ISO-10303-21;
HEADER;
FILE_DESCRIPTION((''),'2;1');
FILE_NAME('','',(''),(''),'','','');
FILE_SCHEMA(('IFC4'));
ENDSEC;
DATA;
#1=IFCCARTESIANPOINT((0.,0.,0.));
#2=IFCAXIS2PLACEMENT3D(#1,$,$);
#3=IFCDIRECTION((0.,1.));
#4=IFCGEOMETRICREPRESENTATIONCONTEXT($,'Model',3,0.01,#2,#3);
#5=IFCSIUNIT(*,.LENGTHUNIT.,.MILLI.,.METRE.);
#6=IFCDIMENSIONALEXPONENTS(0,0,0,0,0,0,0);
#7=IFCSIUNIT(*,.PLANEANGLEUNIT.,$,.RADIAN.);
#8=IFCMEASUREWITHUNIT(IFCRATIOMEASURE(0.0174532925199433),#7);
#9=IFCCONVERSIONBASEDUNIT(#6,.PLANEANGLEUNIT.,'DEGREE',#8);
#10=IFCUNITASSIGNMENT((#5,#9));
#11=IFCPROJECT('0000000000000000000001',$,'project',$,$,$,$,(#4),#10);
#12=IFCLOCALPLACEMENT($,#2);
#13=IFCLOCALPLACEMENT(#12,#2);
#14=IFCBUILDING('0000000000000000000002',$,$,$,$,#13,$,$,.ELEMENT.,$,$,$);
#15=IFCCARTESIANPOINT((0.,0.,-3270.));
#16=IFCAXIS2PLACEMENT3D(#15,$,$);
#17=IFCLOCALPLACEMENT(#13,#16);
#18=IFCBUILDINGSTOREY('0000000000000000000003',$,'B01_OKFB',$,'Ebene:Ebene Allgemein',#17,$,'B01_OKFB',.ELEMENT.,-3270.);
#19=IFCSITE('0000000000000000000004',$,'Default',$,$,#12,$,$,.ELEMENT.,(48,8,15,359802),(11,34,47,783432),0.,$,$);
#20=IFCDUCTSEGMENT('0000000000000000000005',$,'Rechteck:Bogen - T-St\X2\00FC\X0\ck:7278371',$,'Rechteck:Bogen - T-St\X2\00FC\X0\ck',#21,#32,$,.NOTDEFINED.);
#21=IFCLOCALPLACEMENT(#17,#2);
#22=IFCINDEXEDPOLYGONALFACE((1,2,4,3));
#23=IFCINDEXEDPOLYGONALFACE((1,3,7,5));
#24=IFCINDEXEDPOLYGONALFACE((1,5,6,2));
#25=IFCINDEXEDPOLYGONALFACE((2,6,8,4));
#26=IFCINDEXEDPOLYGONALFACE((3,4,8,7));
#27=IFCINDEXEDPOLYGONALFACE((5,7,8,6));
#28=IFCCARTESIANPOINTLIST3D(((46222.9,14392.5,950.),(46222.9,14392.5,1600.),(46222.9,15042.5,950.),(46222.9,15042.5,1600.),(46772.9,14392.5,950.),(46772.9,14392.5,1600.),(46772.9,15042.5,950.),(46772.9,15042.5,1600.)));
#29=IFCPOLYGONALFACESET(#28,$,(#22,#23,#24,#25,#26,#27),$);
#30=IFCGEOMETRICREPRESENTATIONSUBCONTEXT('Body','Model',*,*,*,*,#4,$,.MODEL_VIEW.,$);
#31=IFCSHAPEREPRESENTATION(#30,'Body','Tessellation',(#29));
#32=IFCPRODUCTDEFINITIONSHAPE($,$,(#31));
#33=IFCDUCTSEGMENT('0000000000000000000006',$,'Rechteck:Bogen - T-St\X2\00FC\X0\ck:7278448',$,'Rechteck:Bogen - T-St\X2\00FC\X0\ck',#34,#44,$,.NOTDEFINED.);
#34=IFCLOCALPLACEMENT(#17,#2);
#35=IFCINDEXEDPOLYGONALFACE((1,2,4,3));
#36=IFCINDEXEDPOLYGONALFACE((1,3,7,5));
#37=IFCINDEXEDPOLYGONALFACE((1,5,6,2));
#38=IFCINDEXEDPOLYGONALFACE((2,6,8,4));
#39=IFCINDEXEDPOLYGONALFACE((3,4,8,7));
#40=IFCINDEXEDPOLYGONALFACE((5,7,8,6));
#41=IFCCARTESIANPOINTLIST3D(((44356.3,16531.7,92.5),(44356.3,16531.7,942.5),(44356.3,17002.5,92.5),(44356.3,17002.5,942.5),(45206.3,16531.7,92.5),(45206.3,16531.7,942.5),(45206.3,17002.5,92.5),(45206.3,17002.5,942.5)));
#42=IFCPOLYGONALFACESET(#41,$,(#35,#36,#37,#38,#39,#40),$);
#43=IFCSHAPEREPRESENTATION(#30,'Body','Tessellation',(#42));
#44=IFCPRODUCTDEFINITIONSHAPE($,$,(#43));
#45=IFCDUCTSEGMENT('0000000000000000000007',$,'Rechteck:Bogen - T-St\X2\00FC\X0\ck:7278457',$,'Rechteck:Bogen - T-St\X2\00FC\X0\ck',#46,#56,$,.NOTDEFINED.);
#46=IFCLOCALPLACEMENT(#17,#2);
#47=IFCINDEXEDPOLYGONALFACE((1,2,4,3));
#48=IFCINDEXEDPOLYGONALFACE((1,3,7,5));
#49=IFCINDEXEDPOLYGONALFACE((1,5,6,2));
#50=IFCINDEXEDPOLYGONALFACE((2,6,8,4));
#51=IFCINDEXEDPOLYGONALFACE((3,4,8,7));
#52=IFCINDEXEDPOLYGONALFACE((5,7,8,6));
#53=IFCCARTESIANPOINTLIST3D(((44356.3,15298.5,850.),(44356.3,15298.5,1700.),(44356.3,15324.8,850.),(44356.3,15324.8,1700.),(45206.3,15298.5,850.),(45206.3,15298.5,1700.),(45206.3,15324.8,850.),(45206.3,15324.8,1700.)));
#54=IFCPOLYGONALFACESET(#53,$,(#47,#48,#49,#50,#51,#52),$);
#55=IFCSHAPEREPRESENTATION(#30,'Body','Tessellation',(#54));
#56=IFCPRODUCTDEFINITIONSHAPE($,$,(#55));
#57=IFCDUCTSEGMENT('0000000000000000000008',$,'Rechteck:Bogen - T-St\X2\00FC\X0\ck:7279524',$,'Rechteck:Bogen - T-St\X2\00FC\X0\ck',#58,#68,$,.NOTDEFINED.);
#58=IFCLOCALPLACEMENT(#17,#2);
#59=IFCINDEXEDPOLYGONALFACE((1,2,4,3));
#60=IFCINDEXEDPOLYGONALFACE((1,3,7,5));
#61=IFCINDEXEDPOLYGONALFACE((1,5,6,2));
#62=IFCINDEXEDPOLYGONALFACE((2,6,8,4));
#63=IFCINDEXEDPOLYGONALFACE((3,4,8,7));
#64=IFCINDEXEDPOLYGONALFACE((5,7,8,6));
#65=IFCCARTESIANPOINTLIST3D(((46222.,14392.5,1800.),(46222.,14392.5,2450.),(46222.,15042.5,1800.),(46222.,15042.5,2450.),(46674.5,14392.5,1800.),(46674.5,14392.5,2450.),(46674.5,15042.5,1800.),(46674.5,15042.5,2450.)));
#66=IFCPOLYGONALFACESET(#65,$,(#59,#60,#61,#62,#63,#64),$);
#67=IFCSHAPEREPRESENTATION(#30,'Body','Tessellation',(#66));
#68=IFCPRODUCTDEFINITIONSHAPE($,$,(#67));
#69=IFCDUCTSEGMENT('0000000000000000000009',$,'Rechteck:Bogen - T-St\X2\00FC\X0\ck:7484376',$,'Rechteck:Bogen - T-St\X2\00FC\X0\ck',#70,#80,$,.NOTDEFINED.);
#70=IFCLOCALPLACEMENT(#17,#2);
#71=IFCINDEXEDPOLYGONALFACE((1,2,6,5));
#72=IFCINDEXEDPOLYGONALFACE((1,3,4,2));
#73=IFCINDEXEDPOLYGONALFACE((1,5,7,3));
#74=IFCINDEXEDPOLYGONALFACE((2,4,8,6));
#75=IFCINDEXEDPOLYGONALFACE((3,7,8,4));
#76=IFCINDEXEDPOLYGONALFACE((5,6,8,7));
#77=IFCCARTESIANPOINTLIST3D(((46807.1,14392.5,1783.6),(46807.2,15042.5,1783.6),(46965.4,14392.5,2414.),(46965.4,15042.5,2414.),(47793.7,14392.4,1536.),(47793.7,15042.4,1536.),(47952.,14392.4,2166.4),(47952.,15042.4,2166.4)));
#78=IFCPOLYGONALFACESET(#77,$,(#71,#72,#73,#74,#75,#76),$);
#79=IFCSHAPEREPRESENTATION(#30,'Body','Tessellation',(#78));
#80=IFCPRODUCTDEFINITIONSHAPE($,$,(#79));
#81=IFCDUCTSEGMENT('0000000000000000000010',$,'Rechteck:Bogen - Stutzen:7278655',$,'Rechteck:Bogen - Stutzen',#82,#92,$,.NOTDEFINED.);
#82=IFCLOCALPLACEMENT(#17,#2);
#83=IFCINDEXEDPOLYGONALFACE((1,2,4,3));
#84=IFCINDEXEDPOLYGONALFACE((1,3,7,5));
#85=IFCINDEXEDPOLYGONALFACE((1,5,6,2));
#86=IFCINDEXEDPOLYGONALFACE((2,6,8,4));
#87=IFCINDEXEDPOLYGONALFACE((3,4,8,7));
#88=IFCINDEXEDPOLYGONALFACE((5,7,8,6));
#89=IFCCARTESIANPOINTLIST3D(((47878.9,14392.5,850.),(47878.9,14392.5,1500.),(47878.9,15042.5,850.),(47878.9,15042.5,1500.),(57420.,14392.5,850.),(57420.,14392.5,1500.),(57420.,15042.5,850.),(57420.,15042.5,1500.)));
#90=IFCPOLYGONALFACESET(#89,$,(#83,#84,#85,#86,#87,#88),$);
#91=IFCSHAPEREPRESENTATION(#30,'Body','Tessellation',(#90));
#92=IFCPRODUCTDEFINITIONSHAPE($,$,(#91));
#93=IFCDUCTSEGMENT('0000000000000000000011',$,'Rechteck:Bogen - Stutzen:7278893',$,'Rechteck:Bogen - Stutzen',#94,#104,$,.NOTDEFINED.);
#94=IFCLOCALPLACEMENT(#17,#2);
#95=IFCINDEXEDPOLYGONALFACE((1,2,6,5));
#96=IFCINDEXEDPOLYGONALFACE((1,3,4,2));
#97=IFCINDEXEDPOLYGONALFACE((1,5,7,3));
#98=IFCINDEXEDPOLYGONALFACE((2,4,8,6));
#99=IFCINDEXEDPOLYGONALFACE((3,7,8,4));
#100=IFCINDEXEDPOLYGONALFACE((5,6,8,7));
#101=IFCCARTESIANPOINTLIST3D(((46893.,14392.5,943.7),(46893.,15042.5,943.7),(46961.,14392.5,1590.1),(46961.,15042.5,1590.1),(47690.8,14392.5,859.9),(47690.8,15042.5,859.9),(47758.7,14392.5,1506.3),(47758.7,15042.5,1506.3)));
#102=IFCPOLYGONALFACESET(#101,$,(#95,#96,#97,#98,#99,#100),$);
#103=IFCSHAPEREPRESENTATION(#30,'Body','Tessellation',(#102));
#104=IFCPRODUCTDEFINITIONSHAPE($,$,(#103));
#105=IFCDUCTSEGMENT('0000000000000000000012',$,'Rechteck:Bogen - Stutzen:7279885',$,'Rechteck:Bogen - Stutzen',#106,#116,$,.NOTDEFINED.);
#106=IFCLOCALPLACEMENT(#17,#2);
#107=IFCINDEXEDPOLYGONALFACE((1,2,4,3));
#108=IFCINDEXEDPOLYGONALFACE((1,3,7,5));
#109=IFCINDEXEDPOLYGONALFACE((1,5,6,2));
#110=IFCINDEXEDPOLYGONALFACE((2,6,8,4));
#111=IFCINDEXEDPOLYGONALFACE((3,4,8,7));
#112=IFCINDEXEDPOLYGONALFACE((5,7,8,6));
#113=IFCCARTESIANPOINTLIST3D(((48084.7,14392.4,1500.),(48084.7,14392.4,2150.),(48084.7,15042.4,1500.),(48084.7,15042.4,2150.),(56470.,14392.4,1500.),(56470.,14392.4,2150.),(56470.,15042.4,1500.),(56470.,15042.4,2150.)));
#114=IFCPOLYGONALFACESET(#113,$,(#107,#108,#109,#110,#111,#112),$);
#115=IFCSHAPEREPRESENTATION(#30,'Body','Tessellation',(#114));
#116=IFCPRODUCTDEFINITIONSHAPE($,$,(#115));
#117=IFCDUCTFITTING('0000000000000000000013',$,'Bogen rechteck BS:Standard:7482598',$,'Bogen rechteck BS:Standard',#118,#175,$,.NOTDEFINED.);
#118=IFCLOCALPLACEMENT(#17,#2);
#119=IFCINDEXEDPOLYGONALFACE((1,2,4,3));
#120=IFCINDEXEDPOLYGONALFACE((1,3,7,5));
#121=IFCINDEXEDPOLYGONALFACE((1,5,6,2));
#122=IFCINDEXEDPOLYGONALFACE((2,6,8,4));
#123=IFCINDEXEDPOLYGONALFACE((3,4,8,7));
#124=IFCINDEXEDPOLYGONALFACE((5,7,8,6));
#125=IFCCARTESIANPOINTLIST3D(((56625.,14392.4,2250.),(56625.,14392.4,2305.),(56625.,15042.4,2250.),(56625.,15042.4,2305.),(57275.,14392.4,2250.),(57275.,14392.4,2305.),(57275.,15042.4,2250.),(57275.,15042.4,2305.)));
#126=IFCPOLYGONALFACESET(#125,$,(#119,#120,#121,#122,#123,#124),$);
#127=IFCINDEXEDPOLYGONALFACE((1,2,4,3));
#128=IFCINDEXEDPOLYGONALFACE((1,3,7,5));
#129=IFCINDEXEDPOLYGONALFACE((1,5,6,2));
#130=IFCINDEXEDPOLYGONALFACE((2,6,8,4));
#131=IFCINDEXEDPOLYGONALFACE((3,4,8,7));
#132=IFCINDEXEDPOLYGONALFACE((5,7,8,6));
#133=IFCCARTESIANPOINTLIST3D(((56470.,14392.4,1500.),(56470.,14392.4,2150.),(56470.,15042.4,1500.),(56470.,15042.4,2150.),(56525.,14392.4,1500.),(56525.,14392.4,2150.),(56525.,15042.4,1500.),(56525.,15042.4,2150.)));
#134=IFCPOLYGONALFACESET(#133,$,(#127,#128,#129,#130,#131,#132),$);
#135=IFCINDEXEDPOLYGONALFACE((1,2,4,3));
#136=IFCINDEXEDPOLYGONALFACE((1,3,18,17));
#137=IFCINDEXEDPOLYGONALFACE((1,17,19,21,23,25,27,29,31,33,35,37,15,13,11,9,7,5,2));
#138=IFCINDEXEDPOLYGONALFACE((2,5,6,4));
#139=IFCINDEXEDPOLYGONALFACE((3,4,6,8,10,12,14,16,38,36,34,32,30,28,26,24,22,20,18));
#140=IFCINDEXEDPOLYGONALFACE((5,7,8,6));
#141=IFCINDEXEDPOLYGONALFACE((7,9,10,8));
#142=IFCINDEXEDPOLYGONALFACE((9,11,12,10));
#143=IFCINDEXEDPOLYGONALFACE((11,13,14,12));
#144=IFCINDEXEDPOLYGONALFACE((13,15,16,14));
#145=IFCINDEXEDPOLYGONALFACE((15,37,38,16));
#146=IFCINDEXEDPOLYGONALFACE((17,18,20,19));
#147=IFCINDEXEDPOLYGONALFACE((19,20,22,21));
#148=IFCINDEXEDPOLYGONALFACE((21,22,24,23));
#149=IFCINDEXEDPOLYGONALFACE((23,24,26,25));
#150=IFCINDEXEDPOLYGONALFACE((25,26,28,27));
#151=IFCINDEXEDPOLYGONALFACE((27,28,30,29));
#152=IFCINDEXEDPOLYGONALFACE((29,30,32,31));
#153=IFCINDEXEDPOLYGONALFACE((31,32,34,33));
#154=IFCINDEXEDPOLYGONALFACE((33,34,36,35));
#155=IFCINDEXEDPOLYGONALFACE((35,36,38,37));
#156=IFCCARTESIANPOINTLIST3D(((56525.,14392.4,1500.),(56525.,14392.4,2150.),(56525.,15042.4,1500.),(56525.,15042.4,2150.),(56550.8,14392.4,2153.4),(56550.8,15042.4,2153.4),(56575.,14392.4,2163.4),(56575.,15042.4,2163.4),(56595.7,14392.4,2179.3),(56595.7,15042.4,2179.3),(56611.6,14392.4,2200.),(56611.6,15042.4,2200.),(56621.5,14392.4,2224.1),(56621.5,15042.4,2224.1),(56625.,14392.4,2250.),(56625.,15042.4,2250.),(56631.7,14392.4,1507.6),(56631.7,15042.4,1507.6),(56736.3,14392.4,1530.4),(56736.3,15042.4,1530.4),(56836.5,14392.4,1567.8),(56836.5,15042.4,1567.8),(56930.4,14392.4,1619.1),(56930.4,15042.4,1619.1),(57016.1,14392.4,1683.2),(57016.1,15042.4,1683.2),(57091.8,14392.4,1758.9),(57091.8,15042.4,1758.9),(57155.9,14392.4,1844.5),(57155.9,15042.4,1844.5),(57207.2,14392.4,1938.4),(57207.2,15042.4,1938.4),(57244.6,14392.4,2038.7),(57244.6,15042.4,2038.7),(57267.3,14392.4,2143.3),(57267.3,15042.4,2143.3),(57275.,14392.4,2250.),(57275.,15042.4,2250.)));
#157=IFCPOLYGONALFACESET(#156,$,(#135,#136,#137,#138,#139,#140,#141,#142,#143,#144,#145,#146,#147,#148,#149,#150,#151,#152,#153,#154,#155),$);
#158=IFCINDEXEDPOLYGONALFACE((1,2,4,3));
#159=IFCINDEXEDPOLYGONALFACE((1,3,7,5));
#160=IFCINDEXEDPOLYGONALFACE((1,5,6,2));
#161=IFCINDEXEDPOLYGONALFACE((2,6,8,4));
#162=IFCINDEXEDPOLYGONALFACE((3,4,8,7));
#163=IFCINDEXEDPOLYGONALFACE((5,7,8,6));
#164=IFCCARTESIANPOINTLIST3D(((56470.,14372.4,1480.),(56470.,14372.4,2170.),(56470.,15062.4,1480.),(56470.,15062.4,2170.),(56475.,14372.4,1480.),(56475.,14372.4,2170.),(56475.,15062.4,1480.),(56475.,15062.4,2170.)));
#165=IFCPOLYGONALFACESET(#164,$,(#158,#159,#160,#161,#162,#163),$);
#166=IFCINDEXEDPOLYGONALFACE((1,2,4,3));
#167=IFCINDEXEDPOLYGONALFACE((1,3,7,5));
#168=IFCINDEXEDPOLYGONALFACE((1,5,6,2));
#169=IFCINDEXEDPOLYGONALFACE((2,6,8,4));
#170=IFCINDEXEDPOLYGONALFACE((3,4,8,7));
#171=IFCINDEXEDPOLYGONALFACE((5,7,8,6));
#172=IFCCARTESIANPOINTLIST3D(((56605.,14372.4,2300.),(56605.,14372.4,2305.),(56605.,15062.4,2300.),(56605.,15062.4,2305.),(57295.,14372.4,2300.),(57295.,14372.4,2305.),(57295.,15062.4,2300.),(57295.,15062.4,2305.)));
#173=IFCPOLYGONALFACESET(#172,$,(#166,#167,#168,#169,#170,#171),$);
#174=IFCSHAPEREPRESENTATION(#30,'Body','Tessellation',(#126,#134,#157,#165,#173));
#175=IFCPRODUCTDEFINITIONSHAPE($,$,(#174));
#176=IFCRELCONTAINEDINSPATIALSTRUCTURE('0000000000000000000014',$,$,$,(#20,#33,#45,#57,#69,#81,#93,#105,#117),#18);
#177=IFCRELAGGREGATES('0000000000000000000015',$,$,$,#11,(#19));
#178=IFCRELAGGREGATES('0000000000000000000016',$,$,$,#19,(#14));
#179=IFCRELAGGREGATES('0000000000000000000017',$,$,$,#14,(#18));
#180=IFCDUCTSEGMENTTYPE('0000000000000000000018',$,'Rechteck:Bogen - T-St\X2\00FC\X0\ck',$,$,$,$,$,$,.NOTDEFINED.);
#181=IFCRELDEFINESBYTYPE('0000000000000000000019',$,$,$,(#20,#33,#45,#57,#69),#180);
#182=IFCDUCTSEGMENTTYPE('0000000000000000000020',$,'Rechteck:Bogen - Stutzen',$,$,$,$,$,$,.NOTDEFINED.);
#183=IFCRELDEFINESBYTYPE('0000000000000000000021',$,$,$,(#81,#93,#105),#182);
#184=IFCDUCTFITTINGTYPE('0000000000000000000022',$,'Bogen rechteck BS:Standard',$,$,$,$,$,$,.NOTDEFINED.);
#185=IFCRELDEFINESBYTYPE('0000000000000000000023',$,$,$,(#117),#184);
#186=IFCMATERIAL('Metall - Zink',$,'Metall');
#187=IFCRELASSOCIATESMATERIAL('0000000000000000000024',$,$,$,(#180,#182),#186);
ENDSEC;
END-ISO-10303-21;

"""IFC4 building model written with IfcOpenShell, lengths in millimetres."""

from ifc_helpers import new_model, entity, si_unit, converted_unit, direction, frame, frame_2d, origin, origin_2d_with_axis, place, context, subcontext, project, spatial, polyline, circle_curve, parameter, trimmed, segment, composite_curve, rectangle, outline, extrude, source, transform, mapped, material, type_object, type_shapes, element, save


model = new_model("IFC4")

# Units and contexts
model_context = context("Model", 3, precision=0.01, world=origin(), true_north=direction((0.0, 1.0)))
body_context = subcontext(model_context, "Body", "Model", "MODEL_VIEW")
ifc_project = project(units=[si_unit("LENGTHUNIT", "METRE", prefix="MILLI"), converted_unit("PLANEANGLEUNIT", "DEGREE", entity("IfcRatioMeasure", 0.0174532925199433), si_unit("PLANEANGLEUNIT", "RADIAN"), dimensions=[0, 0, 0, 0, 0, 0, 0])], contexts=[model_context])

# Site, building, storey
site_placement = place(None, origin())
site = spatial("IfcSite", under=ifc_project, at=site_placement, Name="Default", CompositionType="ELEMENT", RefLatitude=(48, 8, 15, 359802), RefLongitude=(11, 34, 47, 783432), RefElevation=0.0)
building_placement = place(site_placement, origin())
building = spatial("IfcBuilding", under=site, at=building_placement, CompositionType="ELEMENT")
storey_placement = place(building_placement, frame((0.0, 0.0, -3270.0)))
storey = spatial("IfcBuildingStorey", under=building, at=storey_placement, Name="B01_OKFB", ObjectType="Ebene:Ebene Allgemein", LongName="B01_OKFB", CompositionType="ELEMENT", Elevation=-3270.0)

# Duct segments
ifc_material = material(Name="Metall - Zink", Category="Metall")
duct_segment_type_1 = type_object("IfcDuctSegmentType", Name="Rechteck:Bogen - T-Stück", PredefinedType="NOTDEFINED", material=ifc_material)
duct_segment_1_placement = place(storey_placement, frame((46222.9, 14392.5, 950.0)))
element("IfcDuctSegment", 1, at=duct_segment_1_placement, inside=storey, type_object=duct_segment_type_1, Name="Rechteck:Bogen - T-Stück:7278371", ObjectType="Rechteck:Bogen - T-Stück", PredefinedType="NOTDEFINED", context=body_context, shape_type="SweptSolid", body=[
    extrude(rectangle(XDim=550.0, YDim=650.0, at=frame_2d((0.0, 0.0), x_axis=(1.0, 0.0))), frame((275.0, 325.0, 0.0)), (0.0, 0.0, 1.0), 650.0),
])
duct_segment_2_placement = place(storey_placement, frame((44356.3, 16531.7, 92.5)))
element("IfcDuctSegment", 2, at=duct_segment_2_placement, inside=storey, type_object=duct_segment_type_1, Name="Rechteck:Bogen - T-Stück:7278448", ObjectType="Rechteck:Bogen - T-Stück", PredefinedType="NOTDEFINED", context=body_context, shape_type="SweptSolid", body=[
    extrude(rectangle(XDim=470.8, YDim=850.0, at=frame_2d((0.0, 0.0), x_axis=(1.0, 0.0))), frame((425.0, 235.4, 0.0), z_axis=(0.0, 0.0, 1.0), x_axis=(0.0, -1.0, 0.0)), (0.0, 0.0, 1.0), 850.0),
])
duct_segment_3_placement = place(storey_placement, frame((44356.3, 15298.5, 850.0)))
element("IfcDuctSegment", 3, at=duct_segment_3_placement, inside=storey, type_object=duct_segment_type_1, Name="Rechteck:Bogen - T-Stück:7278457", ObjectType="Rechteck:Bogen - T-Stück", PredefinedType="NOTDEFINED", context=body_context, shape_type="SweptSolid", body=[
    extrude(rectangle(XDim=26.2, YDim=850.0, at=frame_2d((0.0, 0.0), x_axis=(1.0, 0.0))), frame((425.0, 13.1, 0.0), z_axis=(0.0, 0.0, 1.0), x_axis=(0.0, 1.0, 0.0)), (0.0, 0.0, 1.0), 850.0),
])
duct_segment_4_placement = place(storey_placement, frame((46222.0, 14392.5, 1800.0)))
element("IfcDuctSegment", 4, at=duct_segment_4_placement, inside=storey, type_object=duct_segment_type_1, Name="Rechteck:Bogen - T-Stück:7279524", ObjectType="Rechteck:Bogen - T-Stück", PredefinedType="NOTDEFINED", context=body_context, shape_type="SweptSolid", body=[
    extrude(rectangle(XDim=452.5, YDim=650.0, at=origin_2d_with_axis()), frame((226.2, 325.0, 0.0)), (0.0, 0.0, 1.0), 650.0),
])
duct_segment_5_placement = place(storey_placement, frame((46807.1, 14392.4, 1536.0)))
element("IfcDuctSegment", 5, at=duct_segment_5_placement, inside=storey, type_object=duct_segment_type_1, Name="Rechteck:Bogen - T-Stück:7484376", ObjectType="Rechteck:Bogen - T-Stück", PredefinedType="NOTDEFINED", context=body_context, shape_type="SweptSolid", body=[
    extrude(rectangle(XDim=650.0, YDim=650.0, at=frame_2d((0.0, 0.0), x_axis=(0.0, 1.0))), frame((79.1, 325.0, 562.9), z_axis=(0.969911, -0.000036, -0.243458), x_axis=(0.000037, 1.0, 0.0)), (0.0, 0.0, 1.0), 1017.2),
])

# Duct segments
duct_segment_type_2 = type_object("IfcDuctSegmentType", Name="Rechteck:Bogen - Stutzen", PredefinedType="NOTDEFINED", material=ifc_material)
duct_segment_6_placement = place(storey_placement, frame((47878.9, 14392.5, 850.0)))
element("IfcDuctSegment", 6, at=duct_segment_6_placement, inside=storey, type_object=duct_segment_type_2, Name="Rechteck:Bogen - Stutzen:7278655", ObjectType="Rechteck:Bogen - Stutzen", PredefinedType="NOTDEFINED", context=body_context, shape_type="SweptSolid", body=[
    extrude(rectangle(XDim=9541.1, YDim=650.0, at=frame_2d((0.0, 0.0), x_axis=(1.0, 0.0))), frame((4770.5, 325.0, 0.0), z_axis=(0.0, 0.0, 1.0), x_axis=(-1.0, 0.0, 0.0)), (0.0, 0.0, 1.0), 650.0),
])
duct_segment_7_placement = place(storey_placement, frame((46893.0, 14392.5, 859.9)))
element("IfcDuctSegment", 7, at=duct_segment_7_placement, inside=storey, type_object=duct_segment_type_2, Name="Rechteck:Bogen - Stutzen:7278893", ObjectType="Rechteck:Bogen - Stutzen", PredefinedType="NOTDEFINED", context=body_context, shape_type="SweptSolid", body=[
    extrude(rectangle(XDim=650.0, YDim=650.0, at=frame_2d((0.0, 0.0), x_axis=(0.0, 1.0))), frame((34.0, 325.0, 407.1), z_axis=(0.994522, 0.0, -0.104528), x_axis=(0.0, 1.0, 0.0)), (0.0, 0.0, 1.0), 802.1),
])
duct_segment_8_placement = place(storey_placement, frame((48084.7, 14392.4, 1500.0)))
element("IfcDuctSegment", 8, at=duct_segment_8_placement, inside=storey, type_object=duct_segment_type_2, Name="Rechteck:Bogen - Stutzen:7279885", ObjectType="Rechteck:Bogen - Stutzen", PredefinedType="NOTDEFINED", context=body_context, shape_type="SweptSolid", body=[
    extrude(rectangle(XDim=8385.3, YDim=650.0, at=origin_2d_with_axis()), frame((4192.6, 325.0, 0.0), z_axis=(0.0, 0.0, 1.0), x_axis=(-1.0, 0.0, 0.0)), (0.0, 0.0, 1.0), 650.0),
])

# Duct fitting
duct_fitting_type_1 = type_object("IfcDuctFittingType", Name="Bogen rechteck BS:Standard", PredefinedType="NOTDEFINED")
shared_shape_1 = source(origin(), body_context, "Body", "SweptSolid", [
    extrude(rectangle(XDim=55.0, YDim=650.0, at=origin_2d_with_axis()), frame((0.0, 452.5, -325.0), z_axis=(0.0, 0.0, 1.0), x_axis=(0.0, 1.0, 0.0)), (0.0, 0.0, 1.0), 650.0),
    extrude(rectangle(XDim=650.0, YDim=55.0, at=frame_2d((0.0, 0.0), x_axis=(1.0, 0.0))), frame((-452.5, 0.0, -325.0), z_axis=(0.0, 0.0, 1.0), x_axis=(0.0, -1.0, 0.0)), (0.0, 0.0, 1.0), 650.0),
    extrude(outline(composite_curve([segment(polyline([(-537.5, -212.5), (112.5, -212.5)]), True, "CONTINUOUS"), segment(trimmed(circle_curve(frame_2d((212.5, -212.5), x_axis=(0.0, 1.0)), 100.0), [parameter(0.0)], [parameter(90.0)], True, "PARAMETER"), False, "CONTINUOUS"), segment(polyline([(212.5, -112.5), (212.5, 537.5)]), True, "CONTINUOUS"), segment(trimmed(circle_curve(frame_2d((212.5, -212.5), x_axis=(0.0, 1.0)), 750.0), [parameter(0.0)], [parameter(90.0)], True, "PARAMETER"), True, "CONTINUOUS")], self_intersect=False)), frame((-212.5, 212.5, -325.0), z_axis=(0.0, 0.0, 1.0), x_axis=(-1.0, 0.0, 0.0)), (0.0, 0.0, 1.0), 650.0),
    extrude(rectangle(XDim=5.0, YDim=690.0, at=frame_2d((0.0, 0.0), x_axis=(1.0, 0.0))), frame((-477.5, 0.0, -345.0)), (0.0, 0.0, 1.0), 690.0),
    extrude(rectangle(XDim=5.0, YDim=690.0, at=frame_2d((0.0, 0.0), x_axis=(1.0, 0.0))), frame((0.0, 477.5, -345.0), z_axis=(0.0, 0.0, 1.0), x_axis=(0.0, 1.0, 0.0)), (0.0, 0.0, 1.0), 690.0),
])
type_shapes(duct_fitting_type_1, [shared_shape_1])
for number, where, z_axis, x_axis, name in (
    (9, (56950.0, 14717.4, 1825.0), (0.0, -1.0, 0.0), (1.0, 0.0, 0.0), "Bogen rechteck BS:Standard:7482598"),
):
    element("IfcDuctFitting", number, at=place(storey_placement, frame(where, z_axis=z_axis, x_axis=x_axis)), inside=storey, type_object=duct_fitting_type_1, Name=name, ObjectType="Bogen rechteck BS:Standard", PredefinedType="NOTDEFINED", context=body_context, shape_type="MappedRepresentation", body=[
        mapped(shared_shape_1, transform((0.0, 0.0, 0.0), scale=1.0)),
    ])

save(model, "model.ifc")
